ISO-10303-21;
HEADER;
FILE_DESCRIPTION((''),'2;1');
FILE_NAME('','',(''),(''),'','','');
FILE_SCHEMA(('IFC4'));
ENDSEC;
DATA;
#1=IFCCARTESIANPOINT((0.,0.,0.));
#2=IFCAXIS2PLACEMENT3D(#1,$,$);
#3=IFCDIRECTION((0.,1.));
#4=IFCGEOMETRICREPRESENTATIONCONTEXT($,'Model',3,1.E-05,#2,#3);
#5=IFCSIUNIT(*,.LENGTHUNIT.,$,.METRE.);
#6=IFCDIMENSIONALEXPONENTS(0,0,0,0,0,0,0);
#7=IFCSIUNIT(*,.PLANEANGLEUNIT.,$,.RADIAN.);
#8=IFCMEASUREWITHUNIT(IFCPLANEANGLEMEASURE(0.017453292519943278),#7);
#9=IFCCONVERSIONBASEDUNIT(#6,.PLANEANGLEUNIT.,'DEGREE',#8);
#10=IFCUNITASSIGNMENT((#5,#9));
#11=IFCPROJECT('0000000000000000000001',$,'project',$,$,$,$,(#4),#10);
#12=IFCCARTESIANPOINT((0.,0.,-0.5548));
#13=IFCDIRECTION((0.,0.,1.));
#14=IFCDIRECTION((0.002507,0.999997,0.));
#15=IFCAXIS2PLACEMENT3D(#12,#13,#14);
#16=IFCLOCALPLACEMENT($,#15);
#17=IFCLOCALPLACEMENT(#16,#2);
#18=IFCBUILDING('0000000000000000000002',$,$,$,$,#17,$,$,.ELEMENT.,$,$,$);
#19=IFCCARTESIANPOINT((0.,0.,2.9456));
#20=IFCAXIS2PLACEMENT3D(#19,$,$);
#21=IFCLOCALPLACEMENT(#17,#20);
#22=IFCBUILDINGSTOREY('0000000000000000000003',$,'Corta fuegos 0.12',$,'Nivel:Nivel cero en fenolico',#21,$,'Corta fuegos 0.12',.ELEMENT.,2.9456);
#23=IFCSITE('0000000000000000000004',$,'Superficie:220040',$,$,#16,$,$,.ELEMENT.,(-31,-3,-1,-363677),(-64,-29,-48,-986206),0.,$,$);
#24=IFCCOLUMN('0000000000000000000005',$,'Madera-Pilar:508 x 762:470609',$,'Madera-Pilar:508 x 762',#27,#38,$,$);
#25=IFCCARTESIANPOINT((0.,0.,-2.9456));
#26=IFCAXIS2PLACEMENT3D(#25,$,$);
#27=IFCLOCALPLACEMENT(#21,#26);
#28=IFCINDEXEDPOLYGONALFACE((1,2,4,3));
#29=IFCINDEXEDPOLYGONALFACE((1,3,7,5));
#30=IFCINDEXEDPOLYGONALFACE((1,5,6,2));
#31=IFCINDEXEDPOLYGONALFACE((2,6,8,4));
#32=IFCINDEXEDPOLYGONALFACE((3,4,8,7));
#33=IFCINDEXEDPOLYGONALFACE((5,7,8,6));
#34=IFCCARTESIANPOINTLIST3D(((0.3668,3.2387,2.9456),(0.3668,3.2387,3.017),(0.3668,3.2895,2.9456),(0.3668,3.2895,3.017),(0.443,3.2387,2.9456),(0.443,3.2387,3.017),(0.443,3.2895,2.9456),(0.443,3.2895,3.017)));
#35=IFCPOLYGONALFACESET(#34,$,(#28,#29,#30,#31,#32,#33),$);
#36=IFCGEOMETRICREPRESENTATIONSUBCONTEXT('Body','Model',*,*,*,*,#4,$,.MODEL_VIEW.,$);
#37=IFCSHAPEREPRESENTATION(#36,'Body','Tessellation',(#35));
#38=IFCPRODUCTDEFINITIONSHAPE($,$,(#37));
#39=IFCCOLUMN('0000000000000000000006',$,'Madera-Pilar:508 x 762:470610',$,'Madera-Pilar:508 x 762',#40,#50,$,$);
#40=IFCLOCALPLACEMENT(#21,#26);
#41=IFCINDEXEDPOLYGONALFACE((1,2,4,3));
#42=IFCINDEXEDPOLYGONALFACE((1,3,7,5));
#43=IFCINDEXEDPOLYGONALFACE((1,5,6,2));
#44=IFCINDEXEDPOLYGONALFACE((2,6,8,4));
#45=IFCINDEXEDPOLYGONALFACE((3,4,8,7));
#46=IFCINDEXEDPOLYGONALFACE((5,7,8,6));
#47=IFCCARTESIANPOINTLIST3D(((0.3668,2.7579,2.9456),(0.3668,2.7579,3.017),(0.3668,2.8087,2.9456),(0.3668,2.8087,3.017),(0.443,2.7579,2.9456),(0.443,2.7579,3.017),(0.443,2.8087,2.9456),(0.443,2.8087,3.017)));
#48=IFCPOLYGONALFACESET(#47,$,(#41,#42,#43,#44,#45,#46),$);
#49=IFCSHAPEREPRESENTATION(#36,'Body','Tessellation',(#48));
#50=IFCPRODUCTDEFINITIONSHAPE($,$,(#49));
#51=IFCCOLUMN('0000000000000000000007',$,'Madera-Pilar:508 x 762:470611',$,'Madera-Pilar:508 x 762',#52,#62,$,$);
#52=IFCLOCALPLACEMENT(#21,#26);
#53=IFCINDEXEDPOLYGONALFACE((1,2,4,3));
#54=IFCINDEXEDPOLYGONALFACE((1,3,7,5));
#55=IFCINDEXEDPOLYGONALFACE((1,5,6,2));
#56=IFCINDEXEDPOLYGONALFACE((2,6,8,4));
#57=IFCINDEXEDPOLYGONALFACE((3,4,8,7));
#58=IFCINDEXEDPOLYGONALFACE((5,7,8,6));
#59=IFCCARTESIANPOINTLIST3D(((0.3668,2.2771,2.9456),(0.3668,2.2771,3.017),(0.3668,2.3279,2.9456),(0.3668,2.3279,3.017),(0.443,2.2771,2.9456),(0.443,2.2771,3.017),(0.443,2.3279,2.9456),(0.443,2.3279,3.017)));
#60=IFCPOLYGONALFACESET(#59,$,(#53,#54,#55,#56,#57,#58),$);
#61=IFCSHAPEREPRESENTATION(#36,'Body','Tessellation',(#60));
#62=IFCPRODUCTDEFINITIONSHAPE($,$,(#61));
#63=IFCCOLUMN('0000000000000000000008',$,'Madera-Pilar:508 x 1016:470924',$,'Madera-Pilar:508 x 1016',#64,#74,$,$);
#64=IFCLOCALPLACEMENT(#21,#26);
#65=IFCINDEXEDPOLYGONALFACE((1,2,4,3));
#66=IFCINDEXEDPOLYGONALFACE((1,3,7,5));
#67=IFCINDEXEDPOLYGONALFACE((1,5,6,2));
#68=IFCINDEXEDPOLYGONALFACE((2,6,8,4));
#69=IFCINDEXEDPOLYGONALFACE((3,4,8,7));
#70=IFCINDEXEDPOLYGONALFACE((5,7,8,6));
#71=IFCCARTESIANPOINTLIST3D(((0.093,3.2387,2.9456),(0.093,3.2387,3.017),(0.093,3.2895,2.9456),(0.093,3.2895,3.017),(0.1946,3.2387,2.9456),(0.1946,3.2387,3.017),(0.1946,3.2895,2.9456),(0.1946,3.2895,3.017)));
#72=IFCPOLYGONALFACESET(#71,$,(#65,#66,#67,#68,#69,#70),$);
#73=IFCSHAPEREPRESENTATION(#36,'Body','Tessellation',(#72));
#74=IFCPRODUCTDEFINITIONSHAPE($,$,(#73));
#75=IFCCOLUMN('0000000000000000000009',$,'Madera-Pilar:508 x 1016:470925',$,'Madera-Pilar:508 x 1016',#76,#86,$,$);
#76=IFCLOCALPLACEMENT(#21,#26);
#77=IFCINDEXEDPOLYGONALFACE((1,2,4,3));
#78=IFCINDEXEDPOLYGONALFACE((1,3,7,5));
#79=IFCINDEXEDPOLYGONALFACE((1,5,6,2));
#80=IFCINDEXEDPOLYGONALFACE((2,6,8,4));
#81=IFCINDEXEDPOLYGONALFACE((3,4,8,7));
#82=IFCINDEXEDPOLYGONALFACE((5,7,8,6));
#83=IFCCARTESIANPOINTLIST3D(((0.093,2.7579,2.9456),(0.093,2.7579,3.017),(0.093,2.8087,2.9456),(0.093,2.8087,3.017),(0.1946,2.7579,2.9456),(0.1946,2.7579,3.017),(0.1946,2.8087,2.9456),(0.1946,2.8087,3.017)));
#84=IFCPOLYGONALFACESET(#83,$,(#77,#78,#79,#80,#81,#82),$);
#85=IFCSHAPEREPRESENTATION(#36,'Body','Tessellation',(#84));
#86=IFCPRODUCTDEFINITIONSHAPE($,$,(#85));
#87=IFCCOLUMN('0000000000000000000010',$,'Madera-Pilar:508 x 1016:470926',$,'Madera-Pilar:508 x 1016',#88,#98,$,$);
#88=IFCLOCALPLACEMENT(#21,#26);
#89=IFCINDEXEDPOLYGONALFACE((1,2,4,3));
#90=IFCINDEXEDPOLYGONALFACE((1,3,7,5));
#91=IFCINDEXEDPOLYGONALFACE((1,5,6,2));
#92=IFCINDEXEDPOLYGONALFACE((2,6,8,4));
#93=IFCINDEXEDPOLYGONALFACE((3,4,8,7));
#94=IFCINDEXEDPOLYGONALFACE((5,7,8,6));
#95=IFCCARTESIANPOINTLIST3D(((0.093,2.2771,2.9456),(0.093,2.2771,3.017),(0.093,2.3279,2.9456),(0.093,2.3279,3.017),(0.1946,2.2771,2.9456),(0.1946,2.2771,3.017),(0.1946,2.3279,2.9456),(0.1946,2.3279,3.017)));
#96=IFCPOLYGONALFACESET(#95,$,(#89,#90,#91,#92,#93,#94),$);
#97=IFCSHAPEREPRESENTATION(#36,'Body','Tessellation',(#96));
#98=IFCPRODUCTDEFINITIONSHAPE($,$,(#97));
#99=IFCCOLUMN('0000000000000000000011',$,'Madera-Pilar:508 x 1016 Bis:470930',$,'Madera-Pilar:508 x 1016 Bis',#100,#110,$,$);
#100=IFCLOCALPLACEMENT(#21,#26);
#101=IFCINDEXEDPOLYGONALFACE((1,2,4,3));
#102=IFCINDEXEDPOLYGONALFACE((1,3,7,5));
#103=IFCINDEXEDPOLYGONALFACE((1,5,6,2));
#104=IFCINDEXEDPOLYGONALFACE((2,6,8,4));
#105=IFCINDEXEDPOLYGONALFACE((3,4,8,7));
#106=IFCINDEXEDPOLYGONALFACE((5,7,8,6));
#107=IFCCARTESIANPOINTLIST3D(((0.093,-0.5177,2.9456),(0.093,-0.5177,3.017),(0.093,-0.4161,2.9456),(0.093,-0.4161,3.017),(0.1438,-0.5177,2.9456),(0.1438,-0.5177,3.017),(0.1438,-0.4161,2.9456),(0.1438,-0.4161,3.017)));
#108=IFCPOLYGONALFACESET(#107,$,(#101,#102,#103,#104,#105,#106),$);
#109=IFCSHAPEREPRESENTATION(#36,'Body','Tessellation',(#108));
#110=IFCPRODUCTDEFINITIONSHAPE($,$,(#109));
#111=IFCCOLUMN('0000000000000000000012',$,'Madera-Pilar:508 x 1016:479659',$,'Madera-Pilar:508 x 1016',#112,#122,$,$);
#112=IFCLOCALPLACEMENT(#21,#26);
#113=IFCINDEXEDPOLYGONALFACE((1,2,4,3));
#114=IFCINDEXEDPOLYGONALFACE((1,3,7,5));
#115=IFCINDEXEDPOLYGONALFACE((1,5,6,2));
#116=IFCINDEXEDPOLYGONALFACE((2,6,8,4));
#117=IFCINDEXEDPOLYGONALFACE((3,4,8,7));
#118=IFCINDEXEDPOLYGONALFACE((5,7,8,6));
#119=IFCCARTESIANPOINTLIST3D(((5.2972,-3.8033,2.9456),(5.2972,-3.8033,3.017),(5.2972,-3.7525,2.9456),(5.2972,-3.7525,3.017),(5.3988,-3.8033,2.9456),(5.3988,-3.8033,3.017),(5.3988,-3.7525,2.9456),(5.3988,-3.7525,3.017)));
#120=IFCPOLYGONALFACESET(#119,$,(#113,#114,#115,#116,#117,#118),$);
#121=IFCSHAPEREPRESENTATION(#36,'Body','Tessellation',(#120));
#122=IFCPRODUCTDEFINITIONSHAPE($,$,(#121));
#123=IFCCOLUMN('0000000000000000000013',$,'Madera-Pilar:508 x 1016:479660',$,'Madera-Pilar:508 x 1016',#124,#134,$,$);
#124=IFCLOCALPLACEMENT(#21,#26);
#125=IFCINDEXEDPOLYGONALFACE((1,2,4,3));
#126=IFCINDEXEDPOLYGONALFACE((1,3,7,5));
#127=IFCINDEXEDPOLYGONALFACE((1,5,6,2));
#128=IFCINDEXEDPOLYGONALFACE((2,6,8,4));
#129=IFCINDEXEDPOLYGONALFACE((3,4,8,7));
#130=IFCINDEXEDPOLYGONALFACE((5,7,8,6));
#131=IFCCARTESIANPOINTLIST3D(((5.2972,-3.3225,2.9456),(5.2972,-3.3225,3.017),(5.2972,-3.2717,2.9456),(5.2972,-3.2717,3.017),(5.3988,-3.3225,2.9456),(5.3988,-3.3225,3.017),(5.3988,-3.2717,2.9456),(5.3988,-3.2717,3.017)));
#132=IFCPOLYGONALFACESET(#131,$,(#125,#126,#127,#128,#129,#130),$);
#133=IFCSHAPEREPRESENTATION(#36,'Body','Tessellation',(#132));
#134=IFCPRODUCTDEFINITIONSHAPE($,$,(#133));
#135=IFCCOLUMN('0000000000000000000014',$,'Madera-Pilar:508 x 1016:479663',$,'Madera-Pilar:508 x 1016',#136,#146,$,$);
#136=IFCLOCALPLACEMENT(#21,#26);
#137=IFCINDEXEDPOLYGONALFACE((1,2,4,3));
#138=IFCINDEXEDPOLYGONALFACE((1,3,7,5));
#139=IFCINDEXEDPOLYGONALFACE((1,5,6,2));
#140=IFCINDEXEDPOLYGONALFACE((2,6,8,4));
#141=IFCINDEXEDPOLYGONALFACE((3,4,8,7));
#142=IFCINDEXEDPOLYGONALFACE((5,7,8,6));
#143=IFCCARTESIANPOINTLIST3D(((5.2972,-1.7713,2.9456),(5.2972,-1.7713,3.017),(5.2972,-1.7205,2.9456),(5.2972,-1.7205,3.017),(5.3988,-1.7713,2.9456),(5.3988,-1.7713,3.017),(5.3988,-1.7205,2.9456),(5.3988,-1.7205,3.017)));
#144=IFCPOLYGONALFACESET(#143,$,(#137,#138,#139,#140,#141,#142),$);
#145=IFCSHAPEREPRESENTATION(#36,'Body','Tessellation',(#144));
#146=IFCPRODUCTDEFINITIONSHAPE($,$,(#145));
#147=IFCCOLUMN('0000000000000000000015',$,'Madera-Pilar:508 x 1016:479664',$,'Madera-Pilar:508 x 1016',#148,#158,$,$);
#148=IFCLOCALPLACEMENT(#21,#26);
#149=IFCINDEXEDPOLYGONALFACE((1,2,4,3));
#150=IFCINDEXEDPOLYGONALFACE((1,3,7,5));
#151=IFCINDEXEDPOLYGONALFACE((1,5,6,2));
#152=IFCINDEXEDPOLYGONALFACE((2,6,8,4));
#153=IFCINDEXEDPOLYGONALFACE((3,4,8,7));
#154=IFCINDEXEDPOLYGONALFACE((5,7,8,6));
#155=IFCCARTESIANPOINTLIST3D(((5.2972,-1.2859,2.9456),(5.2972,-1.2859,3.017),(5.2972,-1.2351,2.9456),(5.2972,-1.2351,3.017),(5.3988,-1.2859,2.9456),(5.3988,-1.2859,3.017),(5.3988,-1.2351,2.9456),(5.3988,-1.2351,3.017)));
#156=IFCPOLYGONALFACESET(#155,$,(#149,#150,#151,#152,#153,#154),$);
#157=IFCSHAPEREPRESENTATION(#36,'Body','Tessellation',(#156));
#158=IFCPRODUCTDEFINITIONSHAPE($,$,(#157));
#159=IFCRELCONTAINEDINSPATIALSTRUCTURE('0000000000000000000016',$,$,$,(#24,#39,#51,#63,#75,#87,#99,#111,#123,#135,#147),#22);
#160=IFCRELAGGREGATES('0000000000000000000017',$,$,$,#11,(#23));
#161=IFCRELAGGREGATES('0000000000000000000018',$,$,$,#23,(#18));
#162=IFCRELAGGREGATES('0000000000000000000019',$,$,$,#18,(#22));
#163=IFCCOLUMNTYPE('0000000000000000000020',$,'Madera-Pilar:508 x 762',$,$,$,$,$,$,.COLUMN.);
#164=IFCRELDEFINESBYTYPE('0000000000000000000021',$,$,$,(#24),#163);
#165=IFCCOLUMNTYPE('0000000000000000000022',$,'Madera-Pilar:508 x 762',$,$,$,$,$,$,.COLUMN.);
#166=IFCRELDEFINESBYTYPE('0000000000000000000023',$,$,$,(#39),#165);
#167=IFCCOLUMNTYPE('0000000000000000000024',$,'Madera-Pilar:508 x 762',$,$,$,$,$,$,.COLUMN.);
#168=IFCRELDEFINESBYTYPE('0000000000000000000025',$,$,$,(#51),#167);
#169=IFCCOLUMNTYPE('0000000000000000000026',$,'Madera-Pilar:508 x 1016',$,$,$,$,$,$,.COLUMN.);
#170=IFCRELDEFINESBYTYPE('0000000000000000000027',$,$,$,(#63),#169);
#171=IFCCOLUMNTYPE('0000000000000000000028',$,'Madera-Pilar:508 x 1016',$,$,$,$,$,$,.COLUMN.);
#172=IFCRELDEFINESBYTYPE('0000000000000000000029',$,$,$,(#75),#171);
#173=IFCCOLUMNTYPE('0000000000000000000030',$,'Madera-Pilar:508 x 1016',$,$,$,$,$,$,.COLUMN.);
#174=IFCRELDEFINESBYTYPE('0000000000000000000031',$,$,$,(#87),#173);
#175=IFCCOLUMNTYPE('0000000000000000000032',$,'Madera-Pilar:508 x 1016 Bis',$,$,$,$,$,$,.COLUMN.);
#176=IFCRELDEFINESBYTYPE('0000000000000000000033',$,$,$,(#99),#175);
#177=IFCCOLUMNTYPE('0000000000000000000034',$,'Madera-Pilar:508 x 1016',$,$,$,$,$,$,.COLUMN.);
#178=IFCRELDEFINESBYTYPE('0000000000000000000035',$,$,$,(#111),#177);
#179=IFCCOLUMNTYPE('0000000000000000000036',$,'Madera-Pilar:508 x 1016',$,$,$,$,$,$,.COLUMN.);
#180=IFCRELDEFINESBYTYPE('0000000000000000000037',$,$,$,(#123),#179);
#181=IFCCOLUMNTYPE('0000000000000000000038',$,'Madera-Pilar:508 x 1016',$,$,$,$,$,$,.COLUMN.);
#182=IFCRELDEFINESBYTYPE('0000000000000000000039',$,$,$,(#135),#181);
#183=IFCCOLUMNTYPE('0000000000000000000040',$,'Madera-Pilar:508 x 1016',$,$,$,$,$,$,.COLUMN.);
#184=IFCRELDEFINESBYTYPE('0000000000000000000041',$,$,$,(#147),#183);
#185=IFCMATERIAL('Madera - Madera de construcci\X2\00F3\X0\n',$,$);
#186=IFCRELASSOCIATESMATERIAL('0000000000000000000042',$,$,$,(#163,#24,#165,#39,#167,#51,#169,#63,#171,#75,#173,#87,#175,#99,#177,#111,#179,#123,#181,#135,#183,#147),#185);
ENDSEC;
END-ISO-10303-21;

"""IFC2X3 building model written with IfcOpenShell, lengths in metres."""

from ifc_helpers import new_model, entity, si_unit, converted_unit, direction, frame, frame_2d, origin, origin_2d_with_axis, place, context, subcontext, project, spatial, rectangle, extrude, source, transform, mapped, material, type_object, type_shapes, element, save


model = new_model("IFC2X3")

# Units and contexts
model_context = context("Model", 3, precision=1e-05, world=origin(), true_north=direction((0.0, 1.0)))
body_context = subcontext(model_context, "Body", "Model", "MODEL_VIEW")
ifc_project = project(units=[si_unit("LENGTHUNIT", "METRE"), converted_unit("PLANEANGLEUNIT", "DEGREE", entity("IfcPlaneAngleMeasure", 0.017453292519943278), si_unit("PLANEANGLEUNIT", "RADIAN"), dimensions=[0, 0, 0, 0, 0, 0, 0])], contexts=[model_context])

# Site, building, storey
site_placement = place(None, frame((0.0, 0.0, -0.5548), z_axis=(0.0, 0.0, 1.0), x_axis=(0.002507, 0.999997, 0.0)))
site = spatial("IfcSite", under=ifc_project, at=site_placement, Name="Superficie:220040", CompositionType="ELEMENT", RefLatitude=(-31, -3, -1, -363677), RefLongitude=(-64, -29, -48, -986206), RefElevation=0.0)
building_placement = place(site_placement, origin())
building = spatial("IfcBuilding", under=site, at=building_placement, CompositionType="ELEMENT")
storey_placement = place(building_placement, frame((0.0, 0.0, 2.9456)))
storey = spatial("IfcBuildingStorey", under=building, at=storey_placement, Name="Corta fuegos 0.12", ObjectType="Nivel:Nivel cero en fenolico", LongName="Corta fuegos 0.12", CompositionType="ELEMENT", Elevation=2.9456)

# Columns
ifc_material_1 = material(Name="Madera - Madera de construcción")
column_type_1 = type_object("IfcColumnType", Name="Madera-Pilar:508 x 762", PredefinedType="COLUMN", material=ifc_material_1)
shared_shape_1 = source(origin(), body_context, "Body", "SweptSolid", [
    extrude(rectangle(XDim=0.0762, YDim=0.0508, at=origin_2d_with_axis()), frame((0.4049, 3.2641, 2.9456), z_axis=(0.0, 0.0, 1.0), x_axis=(-1.0, 0.0, 0.0)), (0.0, 0.0, 1.0), 0.0714),
])
type_shapes(column_type_1, [shared_shape_1])
column_1_placement = place(storey_placement, frame((0.0, 0.0, -2.9456)))
element("IfcColumn", 1, at=column_1_placement, inside=storey, type_object=column_type_1, material=ifc_material_1, Name="Madera-Pilar:508 x 762:470609", ObjectType="Madera-Pilar:508 x 762", context=body_context, shape_type="MappedRepresentation", body=[
    mapped(shared_shape_1, transform((0.0, 0.0, 0.0), scale=1.0)),
])
column_type_2 = type_object("IfcColumnType", Name="Madera-Pilar:508 x 762", PredefinedType="COLUMN", material=ifc_material_1)
shared_shape_2 = source(origin(), body_context, "Body", "SweptSolid", [
    extrude(rectangle(XDim=0.0762, YDim=0.0508, at=origin_2d_with_axis()), frame((0.4049, 2.7833, 2.9456), z_axis=(0.0, 0.0, 1.0), x_axis=(-1.0, 0.0, 0.0)), (0.0, 0.0, 1.0), 0.0714),
])
type_shapes(column_type_2, [shared_shape_2])
column_2_placement = place(storey_placement, frame((0.0, 0.0, -2.9456)))
element("IfcColumn", 2, at=column_2_placement, inside=storey, type_object=column_type_2, material=ifc_material_1, Name="Madera-Pilar:508 x 762:470610", ObjectType="Madera-Pilar:508 x 762", context=body_context, shape_type="MappedRepresentation", body=[
    mapped(shared_shape_2, transform((0.0, 0.0, 0.0), scale=1.0)),
])
column_type_3 = type_object("IfcColumnType", Name="Madera-Pilar:508 x 762", PredefinedType="COLUMN", material=ifc_material_1)
shared_shape_3 = source(origin(), body_context, "Body", "SweptSolid", [
    extrude(rectangle(XDim=0.0762, YDim=0.0508, at=origin_2d_with_axis()), frame((0.4049, 2.3025, 2.9456), z_axis=(0.0, 0.0, 1.0), x_axis=(-1.0, 0.0, 0.0)), (0.0, 0.0, 1.0), 0.0714),
])
type_shapes(column_type_3, [shared_shape_3])
column_3_placement = place(storey_placement, frame((0.0, 0.0, -2.9456)))
element("IfcColumn", 3, at=column_3_placement, inside=storey, type_object=column_type_3, material=ifc_material_1, Name="Madera-Pilar:508 x 762:470611", ObjectType="Madera-Pilar:508 x 762", context=body_context, shape_type="MappedRepresentation", body=[
    mapped(shared_shape_3, transform((0.0, 0.0, 0.0), scale=1.0)),
])
column_type_4 = type_object("IfcColumnType", Name="Madera-Pilar:508 x 1016", PredefinedType="COLUMN", material=ifc_material_1)
shared_shape_4 = source(origin(), body_context, "Body", "SweptSolid", [
    extrude(rectangle(XDim=0.1016, YDim=0.0508, at=frame_2d((0.0, 0.0), x_axis=(1.0, 0.0))), frame((0.1438, 3.2641, 2.9456), z_axis=(0.0, 0.0, 1.0), x_axis=(-1.0, 0.0, 0.0)), (0.0, 0.0, 1.0), 0.0714),
])
type_shapes(column_type_4, [shared_shape_4])
column_4_placement = place(storey_placement, frame((0.0, 0.0, -2.9456)))
element("IfcColumn", 4, at=column_4_placement, inside=storey, type_object=column_type_4, material=ifc_material_1, Name="Madera-Pilar:508 x 1016:470924", ObjectType="Madera-Pilar:508 x 1016", context=body_context, shape_type="MappedRepresentation", body=[
    mapped(shared_shape_4, transform((0.0, 0.0, 0.0), scale=1.0)),
])
column_type_5 = type_object("IfcColumnType", Name="Madera-Pilar:508 x 1016", PredefinedType="COLUMN", material=ifc_material_1)
shared_shape_5 = source(origin(), body_context, "Body", "SweptSolid", [
    extrude(rectangle(XDim=0.1016, YDim=0.0508, at=frame_2d((0.0, 0.0), x_axis=(1.0, 0.0))), frame((0.1438, 2.7833, 2.9456), z_axis=(0.0, 0.0, 1.0), x_axis=(-1.0, 0.0, 0.0)), (0.0, 0.0, 1.0), 0.0714),
])
type_shapes(column_type_5, [shared_shape_5])
column_5_placement = place(storey_placement, frame((0.0, 0.0, -2.9456)))
element("IfcColumn", 5, at=column_5_placement, inside=storey, type_object=column_type_5, material=ifc_material_1, Name="Madera-Pilar:508 x 1016:470925", ObjectType="Madera-Pilar:508 x 1016", context=body_context, shape_type="MappedRepresentation", body=[
    mapped(shared_shape_5, transform((0.0, 0.0, 0.0), scale=1.0)),
])
column_type_6 = type_object("IfcColumnType", Name="Madera-Pilar:508 x 1016", PredefinedType="COLUMN", material=ifc_material_1)
shared_shape_6 = source(origin(), body_context, "Body", "SweptSolid", [
    extrude(rectangle(XDim=0.1016, YDim=0.0508, at=frame_2d((0.0, 0.0), x_axis=(1.0, 0.0))), frame((0.1438, 2.3025, 2.9456), z_axis=(0.0, 0.0, 1.0), x_axis=(-1.0, 0.0, 0.0)), (0.0, 0.0, 1.0), 0.0714),
])
type_shapes(column_type_6, [shared_shape_6])
column_6_placement = place(storey_placement, frame((0.0, 0.0, -2.9456)))
element("IfcColumn", 6, at=column_6_placement, inside=storey, type_object=column_type_6, material=ifc_material_1, Name="Madera-Pilar:508 x 1016:470926", ObjectType="Madera-Pilar:508 x 1016", context=body_context, shape_type="MappedRepresentation", body=[
    mapped(shared_shape_6, transform((0.0, 0.0, 0.0), scale=1.0)),
])
column_type_7 = type_object("IfcColumnType", Name="Madera-Pilar:508 x 1016 Bis", PredefinedType="COLUMN", material=ifc_material_1)
shared_shape_7 = source(origin(), body_context, "Body", "SweptSolid", [
    extrude(rectangle(XDim=0.0508, YDim=0.1016, at=frame_2d((0.0, 0.0), x_axis=(1.0, 0.0))), frame((0.1184, -0.4669, 2.9456), z_axis=(0.0, 0.0, 1.0), x_axis=(-1.0, 0.0, 0.0)), (0.0, 0.0, 1.0), 0.0714),
])
type_shapes(column_type_7, [shared_shape_7])
column_7_placement = place(storey_placement, frame((0.0, 0.0, -2.9456)))
element("IfcColumn", 7, at=column_7_placement, inside=storey, type_object=column_type_7, material=ifc_material_1, Name="Madera-Pilar:508 x 1016 Bis:470930", ObjectType="Madera-Pilar:508 x 1016 Bis", context=body_context, shape_type="MappedRepresentation", body=[
    mapped(shared_shape_7, transform((0.0, 0.0, 0.0), scale=1.0)),
])
column_type_8 = type_object("IfcColumnType", Name="Madera-Pilar:508 x 1016", PredefinedType="COLUMN", material=ifc_material_1)
shared_shape_8 = source(origin(), body_context, "Body", "SweptSolid", [
    extrude(rectangle(XDim=0.1016, YDim=0.0508, at=origin_2d_with_axis()), frame((5.348, -3.7779, 2.9456), z_axis=(0.0, 0.0, 1.0), x_axis=(-1.0, 0.0, 0.0)), (0.0, 0.0, 1.0), 0.0714),
])
type_shapes(column_type_8, [shared_shape_8])
column_8_placement = place(storey_placement, frame((0.0, 0.0, -2.9456)))
element("IfcColumn", 8, at=column_8_placement, inside=storey, type_object=column_type_8, material=ifc_material_1, Name="Madera-Pilar:508 x 1016:479659", ObjectType="Madera-Pilar:508 x 1016", context=body_context, shape_type="MappedRepresentation", body=[
    mapped(shared_shape_8, transform((0.0, 0.0, 0.0), scale=1.0)),
])
column_type_9 = type_object("IfcColumnType", Name="Madera-Pilar:508 x 1016", PredefinedType="COLUMN", material=ifc_material_1)
shared_shape_9 = source(origin(), body_context, "Body", "SweptSolid", [
    extrude(rectangle(XDim=0.1016, YDim=0.0508, at=origin_2d_with_axis()), frame((5.348, -3.2971, 2.9456), z_axis=(0.0, 0.0, 1.0), x_axis=(-1.0, 0.0, 0.0)), (0.0, 0.0, 1.0), 0.0714),
])
type_shapes(column_type_9, [shared_shape_9])
column_9_placement = place(storey_placement, frame((0.0, 0.0, -2.9456)))
element("IfcColumn", 9, at=column_9_placement, inside=storey, type_object=column_type_9, material=ifc_material_1, Name="Madera-Pilar:508 x 1016:479660", ObjectType="Madera-Pilar:508 x 1016", context=body_context, shape_type="MappedRepresentation", body=[
    mapped(shared_shape_9, transform((0.0, 0.0, 0.0), scale=1.0)),
])
column_type_10 = type_object("IfcColumnType", Name="Madera-Pilar:508 x 1016", PredefinedType="COLUMN", material=ifc_material_1)
shared_shape_10 = source(origin(), body_context, "Body", "SweptSolid", [
    extrude(rectangle(XDim=0.1016, YDim=0.0508, at=origin_2d_with_axis()), frame((5.348, -1.7459, 2.9456), z_axis=(0.0, 0.0, 1.0), x_axis=(-1.0, 0.0, 0.0)), (0.0, 0.0, 1.0), 0.0714),
])
type_shapes(column_type_10, [shared_shape_10])
column_10_placement = place(storey_placement, frame((0.0, 0.0, -2.9456)))
element("IfcColumn", 10, at=column_10_placement, inside=storey, type_object=column_type_10, material=ifc_material_1, Name="Madera-Pilar:508 x 1016:479663", ObjectType="Madera-Pilar:508 x 1016", context=body_context, shape_type="MappedRepresentation", body=[
    mapped(shared_shape_10, transform((0.0, 0.0, 0.0), scale=1.0)),
])
column_type_11 = type_object("IfcColumnType", Name="Madera-Pilar:508 x 1016", PredefinedType="COLUMN", material=ifc_material_1)
shared_shape_11 = source(origin(), body_context, "Body", "SweptSolid", [
    extrude(rectangle(XDim=0.1016, YDim=0.0508, at=origin_2d_with_axis()), frame((5.348, -1.2605, 2.9456), z_axis=(0.0, 0.0, 1.0), x_axis=(-1.0, 0.0, 0.0)), (0.0, 0.0, 1.0), 0.0714),
])
type_shapes(column_type_11, [shared_shape_11])
column_11_placement = place(storey_placement, frame((0.0, 0.0, -2.9456)))
element("IfcColumn", 11, at=column_11_placement, inside=storey, type_object=column_type_11, material=ifc_material_1, Name="Madera-Pilar:508 x 1016:479664", ObjectType="Madera-Pilar:508 x 1016", context=body_context, shape_type="MappedRepresentation", body=[
    mapped(shared_shape_11, transform((0.0, 0.0, 0.0), scale=1.0)),
])

save(model, "model.ifc")
